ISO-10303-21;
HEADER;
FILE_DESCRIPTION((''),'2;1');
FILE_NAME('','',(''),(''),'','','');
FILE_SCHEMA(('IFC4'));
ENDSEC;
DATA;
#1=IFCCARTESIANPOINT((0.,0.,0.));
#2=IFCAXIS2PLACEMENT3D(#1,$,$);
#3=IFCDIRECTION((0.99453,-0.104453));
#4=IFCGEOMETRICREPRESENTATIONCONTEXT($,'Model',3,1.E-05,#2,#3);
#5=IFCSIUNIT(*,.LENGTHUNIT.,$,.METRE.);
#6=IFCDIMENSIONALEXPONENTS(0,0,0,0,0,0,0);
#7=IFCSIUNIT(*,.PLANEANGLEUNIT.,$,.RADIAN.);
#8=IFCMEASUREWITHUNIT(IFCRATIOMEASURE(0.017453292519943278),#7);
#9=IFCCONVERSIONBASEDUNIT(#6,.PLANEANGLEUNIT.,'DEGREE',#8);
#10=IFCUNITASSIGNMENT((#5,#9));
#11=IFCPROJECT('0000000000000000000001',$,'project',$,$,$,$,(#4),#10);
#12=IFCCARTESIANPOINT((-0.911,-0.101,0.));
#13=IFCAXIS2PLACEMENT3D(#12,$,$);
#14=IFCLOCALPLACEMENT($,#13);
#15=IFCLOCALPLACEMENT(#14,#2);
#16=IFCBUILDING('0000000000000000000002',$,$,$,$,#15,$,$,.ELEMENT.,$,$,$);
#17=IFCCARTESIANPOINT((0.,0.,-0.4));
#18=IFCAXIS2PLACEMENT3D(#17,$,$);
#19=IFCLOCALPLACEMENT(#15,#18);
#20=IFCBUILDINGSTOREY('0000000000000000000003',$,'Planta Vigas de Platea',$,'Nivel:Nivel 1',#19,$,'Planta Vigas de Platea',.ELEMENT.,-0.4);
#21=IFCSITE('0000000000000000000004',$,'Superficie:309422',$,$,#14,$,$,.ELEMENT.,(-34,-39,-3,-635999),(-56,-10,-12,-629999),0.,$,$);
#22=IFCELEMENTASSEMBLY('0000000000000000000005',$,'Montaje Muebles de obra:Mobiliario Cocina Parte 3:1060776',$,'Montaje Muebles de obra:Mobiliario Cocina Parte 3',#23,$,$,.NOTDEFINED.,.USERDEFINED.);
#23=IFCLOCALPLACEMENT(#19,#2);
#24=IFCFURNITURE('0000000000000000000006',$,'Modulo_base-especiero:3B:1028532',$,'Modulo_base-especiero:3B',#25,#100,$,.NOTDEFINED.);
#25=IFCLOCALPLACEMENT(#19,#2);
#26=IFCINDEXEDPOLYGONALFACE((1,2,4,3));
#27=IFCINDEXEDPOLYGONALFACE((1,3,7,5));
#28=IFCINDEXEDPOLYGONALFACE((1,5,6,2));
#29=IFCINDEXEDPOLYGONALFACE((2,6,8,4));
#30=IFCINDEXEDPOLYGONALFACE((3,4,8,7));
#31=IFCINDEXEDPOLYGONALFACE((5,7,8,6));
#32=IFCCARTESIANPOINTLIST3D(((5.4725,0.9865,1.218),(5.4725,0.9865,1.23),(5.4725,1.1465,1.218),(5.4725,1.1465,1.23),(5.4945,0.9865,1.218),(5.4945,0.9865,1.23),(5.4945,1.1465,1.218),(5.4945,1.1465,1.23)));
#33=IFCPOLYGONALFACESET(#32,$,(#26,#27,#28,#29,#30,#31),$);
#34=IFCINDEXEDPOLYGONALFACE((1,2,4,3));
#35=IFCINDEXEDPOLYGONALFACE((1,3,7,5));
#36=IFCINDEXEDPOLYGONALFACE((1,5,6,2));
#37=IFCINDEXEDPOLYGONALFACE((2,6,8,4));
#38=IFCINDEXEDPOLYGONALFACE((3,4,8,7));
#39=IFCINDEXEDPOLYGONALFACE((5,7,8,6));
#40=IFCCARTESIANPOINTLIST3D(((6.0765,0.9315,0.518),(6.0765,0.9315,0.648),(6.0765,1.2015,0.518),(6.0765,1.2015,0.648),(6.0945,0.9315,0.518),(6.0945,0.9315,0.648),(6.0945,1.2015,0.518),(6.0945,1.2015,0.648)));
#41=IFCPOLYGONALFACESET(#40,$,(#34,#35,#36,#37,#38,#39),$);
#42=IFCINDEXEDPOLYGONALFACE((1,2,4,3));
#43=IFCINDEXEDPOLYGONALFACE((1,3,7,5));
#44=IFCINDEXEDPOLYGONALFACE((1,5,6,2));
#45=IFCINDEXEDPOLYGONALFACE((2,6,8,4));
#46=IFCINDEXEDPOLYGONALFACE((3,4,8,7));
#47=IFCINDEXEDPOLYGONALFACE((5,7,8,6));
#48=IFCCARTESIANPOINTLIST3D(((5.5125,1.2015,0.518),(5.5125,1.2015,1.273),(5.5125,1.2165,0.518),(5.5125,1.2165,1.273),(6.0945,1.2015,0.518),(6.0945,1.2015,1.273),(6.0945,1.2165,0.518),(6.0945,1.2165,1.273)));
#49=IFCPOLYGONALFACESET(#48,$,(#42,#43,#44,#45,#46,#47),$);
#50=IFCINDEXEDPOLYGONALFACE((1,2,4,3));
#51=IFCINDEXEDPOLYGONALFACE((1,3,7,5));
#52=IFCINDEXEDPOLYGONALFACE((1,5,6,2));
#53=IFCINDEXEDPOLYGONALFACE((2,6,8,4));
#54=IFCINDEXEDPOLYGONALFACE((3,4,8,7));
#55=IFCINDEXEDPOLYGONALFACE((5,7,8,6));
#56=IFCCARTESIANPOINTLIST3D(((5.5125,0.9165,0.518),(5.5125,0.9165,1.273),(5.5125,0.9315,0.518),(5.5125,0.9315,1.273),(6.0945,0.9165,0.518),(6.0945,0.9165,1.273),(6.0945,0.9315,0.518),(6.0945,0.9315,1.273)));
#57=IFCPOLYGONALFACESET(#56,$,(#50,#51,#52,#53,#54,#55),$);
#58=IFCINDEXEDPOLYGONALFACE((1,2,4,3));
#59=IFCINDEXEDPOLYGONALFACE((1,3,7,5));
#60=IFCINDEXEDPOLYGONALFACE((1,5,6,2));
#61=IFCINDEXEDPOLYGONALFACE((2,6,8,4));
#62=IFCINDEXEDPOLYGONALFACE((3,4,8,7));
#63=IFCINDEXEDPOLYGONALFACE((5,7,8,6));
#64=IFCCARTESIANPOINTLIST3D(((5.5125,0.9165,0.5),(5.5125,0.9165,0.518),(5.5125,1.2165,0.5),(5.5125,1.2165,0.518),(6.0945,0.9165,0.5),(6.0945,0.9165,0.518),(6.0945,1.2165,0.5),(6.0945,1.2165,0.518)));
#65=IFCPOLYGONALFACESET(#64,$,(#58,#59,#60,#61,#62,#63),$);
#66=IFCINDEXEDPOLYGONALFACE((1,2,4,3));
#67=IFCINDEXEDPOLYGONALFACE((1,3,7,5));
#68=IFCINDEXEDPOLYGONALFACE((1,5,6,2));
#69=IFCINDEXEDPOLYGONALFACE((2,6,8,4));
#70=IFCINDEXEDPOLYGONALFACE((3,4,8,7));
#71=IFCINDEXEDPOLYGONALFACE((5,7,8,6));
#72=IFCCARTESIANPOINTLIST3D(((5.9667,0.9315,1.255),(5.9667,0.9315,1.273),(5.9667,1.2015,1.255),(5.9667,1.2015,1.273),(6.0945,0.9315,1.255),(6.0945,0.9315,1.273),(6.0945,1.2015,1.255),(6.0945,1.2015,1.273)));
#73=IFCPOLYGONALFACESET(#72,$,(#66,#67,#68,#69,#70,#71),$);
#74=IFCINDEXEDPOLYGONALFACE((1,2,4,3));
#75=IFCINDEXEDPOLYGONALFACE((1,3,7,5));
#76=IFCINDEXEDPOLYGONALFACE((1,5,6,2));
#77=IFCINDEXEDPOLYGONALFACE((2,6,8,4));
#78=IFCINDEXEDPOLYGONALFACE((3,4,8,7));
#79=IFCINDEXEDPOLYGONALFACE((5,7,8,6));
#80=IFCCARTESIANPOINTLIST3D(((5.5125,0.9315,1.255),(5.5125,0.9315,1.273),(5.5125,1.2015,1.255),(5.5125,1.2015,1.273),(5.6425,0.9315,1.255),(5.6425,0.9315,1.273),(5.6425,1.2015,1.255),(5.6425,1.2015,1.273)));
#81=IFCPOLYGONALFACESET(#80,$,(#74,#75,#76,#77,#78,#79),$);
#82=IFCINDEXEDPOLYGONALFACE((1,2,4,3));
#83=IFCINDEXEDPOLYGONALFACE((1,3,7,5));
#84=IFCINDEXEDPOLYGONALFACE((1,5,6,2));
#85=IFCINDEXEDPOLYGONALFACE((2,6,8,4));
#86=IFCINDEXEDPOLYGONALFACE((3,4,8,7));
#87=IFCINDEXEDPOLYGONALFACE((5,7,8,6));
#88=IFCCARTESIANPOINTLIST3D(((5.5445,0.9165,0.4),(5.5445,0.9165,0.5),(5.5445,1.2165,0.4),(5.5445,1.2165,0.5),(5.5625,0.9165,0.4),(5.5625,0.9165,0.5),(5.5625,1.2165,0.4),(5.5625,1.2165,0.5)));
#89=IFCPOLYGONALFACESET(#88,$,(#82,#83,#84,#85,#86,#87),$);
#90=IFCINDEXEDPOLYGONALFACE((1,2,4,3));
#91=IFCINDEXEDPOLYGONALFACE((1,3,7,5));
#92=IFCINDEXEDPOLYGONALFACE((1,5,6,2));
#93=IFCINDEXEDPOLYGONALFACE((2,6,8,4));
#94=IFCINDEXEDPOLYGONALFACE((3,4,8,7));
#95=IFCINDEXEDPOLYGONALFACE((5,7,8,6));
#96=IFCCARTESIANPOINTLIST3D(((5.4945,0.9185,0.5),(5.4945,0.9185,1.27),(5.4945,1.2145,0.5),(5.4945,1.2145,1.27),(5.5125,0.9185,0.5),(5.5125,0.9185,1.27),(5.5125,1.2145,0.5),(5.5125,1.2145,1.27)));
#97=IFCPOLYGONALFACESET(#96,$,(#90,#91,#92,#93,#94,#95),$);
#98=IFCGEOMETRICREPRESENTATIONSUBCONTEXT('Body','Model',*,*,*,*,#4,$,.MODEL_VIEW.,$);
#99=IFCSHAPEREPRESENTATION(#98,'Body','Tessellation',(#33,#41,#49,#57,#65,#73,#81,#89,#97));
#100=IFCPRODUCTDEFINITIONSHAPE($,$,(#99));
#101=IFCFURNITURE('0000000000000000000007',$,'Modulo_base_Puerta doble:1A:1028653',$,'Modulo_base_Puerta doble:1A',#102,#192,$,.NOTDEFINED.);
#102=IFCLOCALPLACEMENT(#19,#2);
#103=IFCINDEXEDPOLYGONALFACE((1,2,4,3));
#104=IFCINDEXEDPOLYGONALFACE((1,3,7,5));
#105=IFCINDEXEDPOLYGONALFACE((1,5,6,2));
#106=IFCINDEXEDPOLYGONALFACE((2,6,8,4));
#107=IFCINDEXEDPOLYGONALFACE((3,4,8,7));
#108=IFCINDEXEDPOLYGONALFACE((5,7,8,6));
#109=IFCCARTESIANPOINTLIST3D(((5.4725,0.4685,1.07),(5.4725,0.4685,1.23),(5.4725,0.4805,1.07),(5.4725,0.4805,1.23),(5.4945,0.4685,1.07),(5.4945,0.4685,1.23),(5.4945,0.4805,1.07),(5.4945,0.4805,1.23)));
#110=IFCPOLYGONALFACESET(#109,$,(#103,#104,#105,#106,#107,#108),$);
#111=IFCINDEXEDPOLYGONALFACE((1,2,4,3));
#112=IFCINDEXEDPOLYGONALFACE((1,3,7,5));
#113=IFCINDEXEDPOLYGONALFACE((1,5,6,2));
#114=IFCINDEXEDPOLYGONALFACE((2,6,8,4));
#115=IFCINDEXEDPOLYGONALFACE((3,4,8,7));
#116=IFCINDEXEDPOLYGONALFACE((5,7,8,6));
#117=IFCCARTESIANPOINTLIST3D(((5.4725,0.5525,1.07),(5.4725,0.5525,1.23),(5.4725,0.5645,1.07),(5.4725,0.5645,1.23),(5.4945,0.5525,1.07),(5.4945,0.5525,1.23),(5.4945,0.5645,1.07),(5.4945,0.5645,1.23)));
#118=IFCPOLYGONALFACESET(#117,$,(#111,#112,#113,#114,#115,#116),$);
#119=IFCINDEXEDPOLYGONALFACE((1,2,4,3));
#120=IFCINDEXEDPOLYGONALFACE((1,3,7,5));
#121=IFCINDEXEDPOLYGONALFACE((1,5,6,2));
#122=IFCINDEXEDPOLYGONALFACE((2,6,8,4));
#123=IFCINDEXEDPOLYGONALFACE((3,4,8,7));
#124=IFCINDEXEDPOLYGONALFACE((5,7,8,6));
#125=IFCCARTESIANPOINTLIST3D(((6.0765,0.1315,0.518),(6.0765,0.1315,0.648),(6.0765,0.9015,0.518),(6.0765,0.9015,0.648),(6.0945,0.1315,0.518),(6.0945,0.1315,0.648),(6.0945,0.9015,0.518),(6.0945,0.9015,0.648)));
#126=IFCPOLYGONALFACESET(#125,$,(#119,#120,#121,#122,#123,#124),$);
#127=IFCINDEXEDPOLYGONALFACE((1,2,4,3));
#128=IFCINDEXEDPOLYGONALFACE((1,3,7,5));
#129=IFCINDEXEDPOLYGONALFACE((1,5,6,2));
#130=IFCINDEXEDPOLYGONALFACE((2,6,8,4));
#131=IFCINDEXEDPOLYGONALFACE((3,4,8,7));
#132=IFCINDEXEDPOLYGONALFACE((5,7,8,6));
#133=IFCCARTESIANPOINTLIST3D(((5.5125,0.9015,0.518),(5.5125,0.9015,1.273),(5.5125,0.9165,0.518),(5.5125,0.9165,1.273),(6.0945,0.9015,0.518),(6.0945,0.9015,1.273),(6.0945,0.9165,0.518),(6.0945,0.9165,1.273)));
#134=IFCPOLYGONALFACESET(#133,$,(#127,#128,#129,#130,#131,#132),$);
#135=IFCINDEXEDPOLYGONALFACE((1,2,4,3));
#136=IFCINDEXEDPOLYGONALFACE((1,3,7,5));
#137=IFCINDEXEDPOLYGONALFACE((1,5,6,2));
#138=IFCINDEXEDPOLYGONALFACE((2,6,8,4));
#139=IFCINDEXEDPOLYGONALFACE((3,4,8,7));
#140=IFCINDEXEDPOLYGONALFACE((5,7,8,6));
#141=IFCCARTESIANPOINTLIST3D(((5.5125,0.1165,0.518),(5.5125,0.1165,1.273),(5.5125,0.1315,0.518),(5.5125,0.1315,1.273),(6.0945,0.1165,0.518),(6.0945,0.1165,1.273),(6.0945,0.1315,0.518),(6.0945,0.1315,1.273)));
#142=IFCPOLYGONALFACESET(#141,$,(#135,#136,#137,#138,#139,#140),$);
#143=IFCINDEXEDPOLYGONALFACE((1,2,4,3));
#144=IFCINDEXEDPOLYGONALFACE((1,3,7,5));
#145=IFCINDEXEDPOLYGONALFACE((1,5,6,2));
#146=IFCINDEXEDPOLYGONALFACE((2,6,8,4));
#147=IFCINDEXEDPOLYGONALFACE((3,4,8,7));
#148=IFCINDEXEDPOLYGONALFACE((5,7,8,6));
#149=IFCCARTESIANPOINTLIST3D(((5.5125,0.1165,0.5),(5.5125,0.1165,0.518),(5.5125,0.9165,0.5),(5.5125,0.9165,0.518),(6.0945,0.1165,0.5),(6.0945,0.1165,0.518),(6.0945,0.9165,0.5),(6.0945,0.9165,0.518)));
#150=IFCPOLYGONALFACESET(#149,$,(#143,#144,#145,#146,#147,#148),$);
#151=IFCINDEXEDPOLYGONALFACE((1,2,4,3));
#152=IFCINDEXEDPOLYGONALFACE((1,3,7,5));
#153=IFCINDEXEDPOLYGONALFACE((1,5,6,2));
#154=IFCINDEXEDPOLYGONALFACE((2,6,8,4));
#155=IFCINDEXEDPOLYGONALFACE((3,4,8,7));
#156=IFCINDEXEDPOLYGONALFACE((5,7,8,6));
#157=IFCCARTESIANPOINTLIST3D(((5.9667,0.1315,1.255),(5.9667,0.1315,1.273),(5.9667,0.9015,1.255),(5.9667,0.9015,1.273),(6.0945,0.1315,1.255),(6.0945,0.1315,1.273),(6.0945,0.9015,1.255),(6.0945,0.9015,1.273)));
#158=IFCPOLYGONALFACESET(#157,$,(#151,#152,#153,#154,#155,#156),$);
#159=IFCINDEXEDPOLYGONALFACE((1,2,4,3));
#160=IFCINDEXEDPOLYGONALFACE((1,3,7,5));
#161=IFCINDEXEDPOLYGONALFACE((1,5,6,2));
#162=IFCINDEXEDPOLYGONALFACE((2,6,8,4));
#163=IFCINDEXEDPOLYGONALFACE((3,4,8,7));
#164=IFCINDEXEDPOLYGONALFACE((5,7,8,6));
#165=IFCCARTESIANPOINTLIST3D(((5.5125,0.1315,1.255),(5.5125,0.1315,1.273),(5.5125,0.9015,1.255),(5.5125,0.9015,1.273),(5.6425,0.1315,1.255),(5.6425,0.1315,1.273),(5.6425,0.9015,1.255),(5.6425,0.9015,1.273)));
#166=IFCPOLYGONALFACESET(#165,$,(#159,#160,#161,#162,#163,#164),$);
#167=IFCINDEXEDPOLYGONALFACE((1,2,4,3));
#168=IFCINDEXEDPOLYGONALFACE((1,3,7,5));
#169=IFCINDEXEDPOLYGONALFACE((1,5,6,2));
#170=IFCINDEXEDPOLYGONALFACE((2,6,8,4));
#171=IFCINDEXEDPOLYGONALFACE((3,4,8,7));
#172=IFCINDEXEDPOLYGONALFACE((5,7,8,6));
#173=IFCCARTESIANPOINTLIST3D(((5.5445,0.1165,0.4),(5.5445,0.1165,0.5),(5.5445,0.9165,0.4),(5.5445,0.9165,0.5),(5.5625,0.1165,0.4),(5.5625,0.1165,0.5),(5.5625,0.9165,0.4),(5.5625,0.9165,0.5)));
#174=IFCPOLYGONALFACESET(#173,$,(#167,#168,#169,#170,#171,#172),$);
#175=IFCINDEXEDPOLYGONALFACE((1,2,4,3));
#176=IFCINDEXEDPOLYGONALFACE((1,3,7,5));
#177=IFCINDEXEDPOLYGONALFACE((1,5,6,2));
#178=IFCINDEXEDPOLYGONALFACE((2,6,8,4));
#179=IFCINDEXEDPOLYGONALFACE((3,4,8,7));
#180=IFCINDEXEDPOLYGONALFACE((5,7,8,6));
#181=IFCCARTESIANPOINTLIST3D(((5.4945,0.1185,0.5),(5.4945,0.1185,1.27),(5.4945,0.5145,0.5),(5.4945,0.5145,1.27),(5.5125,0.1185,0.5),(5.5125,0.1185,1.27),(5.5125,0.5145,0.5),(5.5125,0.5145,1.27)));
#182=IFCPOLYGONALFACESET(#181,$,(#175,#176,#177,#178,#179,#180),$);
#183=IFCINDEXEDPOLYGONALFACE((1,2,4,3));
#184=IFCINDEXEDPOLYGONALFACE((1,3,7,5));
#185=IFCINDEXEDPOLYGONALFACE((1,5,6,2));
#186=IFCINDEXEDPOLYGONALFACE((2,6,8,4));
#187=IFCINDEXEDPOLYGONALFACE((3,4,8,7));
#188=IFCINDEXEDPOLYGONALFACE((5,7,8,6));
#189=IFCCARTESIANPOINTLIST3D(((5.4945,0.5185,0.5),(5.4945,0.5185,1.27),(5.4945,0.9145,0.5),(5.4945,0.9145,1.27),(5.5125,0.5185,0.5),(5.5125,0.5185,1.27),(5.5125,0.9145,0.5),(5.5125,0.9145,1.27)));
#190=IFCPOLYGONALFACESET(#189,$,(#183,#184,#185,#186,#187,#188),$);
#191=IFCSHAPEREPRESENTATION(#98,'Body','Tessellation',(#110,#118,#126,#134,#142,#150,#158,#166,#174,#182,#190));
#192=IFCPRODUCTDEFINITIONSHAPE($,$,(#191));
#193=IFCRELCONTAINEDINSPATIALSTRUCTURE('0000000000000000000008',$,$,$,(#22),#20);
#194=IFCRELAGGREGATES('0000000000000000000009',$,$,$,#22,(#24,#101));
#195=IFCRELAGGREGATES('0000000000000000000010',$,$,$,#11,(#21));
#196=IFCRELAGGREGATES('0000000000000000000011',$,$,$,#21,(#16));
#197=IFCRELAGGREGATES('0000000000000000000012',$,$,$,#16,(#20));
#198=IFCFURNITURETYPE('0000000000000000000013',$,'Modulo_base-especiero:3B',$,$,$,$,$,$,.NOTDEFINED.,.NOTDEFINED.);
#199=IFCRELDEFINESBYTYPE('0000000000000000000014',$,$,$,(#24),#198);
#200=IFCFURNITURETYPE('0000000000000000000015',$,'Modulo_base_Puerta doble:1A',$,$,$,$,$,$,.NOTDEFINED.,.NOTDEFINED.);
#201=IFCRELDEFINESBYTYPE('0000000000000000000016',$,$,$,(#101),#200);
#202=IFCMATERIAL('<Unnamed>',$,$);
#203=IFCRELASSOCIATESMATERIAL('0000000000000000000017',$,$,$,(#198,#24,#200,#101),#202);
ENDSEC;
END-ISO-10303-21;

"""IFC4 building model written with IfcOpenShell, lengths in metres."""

from ifc_helpers import new_model, entity, si_unit, converted_unit, direction, frame, frame_2d, origin, origin_2d_with_axis, place, context, subcontext, project, spatial, rectangle, extrude, source, transform, mapped, material, type_object, type_shapes, element, aggregate, save


model = new_model("IFC4")

# Units and contexts
model_context = context("Model", 3, precision=1e-05, world=origin(), true_north=direction((0.99453, -0.104453)))
body_context = subcontext(model_context, "Body", "Model", "MODEL_VIEW")
ifc_project = project(units=[si_unit("LENGTHUNIT", "METRE"), converted_unit("PLANEANGLEUNIT", "DEGREE", entity("IfcRatioMeasure", 0.017453292519943278), si_unit("PLANEANGLEUNIT", "RADIAN"), dimensions=[0, 0, 0, 0, 0, 0, 0])], contexts=[model_context])

# Site, building, storey
site_placement = place(None, frame((-0.911, -0.101, 0.0)))
site = spatial("IfcSite", under=ifc_project, at=site_placement, Name="Superficie:309422", CompositionType="ELEMENT", RefLatitude=(-34, -39, -3, -635999), RefLongitude=(-56, -10, -12, -629999), RefElevation=0.0)
building_placement = place(site_placement, origin())
building = spatial("IfcBuilding", under=site, at=building_placement, CompositionType="ELEMENT")
storey_placement = place(building_placement, frame((0.0, 0.0, -0.4)))
storey = spatial("IfcBuildingStorey", under=building, at=storey_placement, Name="Planta Vigas de Platea", ObjectType="Nivel:Nivel 1", LongName="Planta Vigas de Platea", CompositionType="ELEMENT", Elevation=-0.4)

# Element assembly, furniture
ifc_material_1 = material(Name="<Unnamed>")
assembly_1_placement = place(storey_placement, origin())
assembly_1 = element("IfcElementAssembly", 1, at=assembly_1_placement, inside=storey, Name="Montaje Muebles de obra:Mobiliario Cocina Parte 3:1060776", ObjectType="Montaje Muebles de obra:Mobiliario Cocina Parte 3", AssemblyPlace="NOTDEFINED", PredefinedType="USERDEFINED")
furniture_type_1 = type_object("IfcFurnitureType", Name="Modulo_base-especiero:3B", AssemblyPlace="NOTDEFINED", PredefinedType="NOTDEFINED", material=ifc_material_1)
shared_shape_1 = source(origin(), body_context, "Body", "SweptSolid", [
    extrude(rectangle(XDim=0.022, YDim=0.16, at=frame_2d((0.0, 0.0), x_axis=(1.0, 0.0))), frame((0.011, 0.15, 0.818)), (0.0, 0.0, 1.0), 0.012),
    extrude(rectangle(XDim=0.27, YDim=0.018, at=frame_2d((0.0, 0.0), x_axis=(1.0, 0.0))), frame((0.613, 0.15, 0.118), z_axis=(0.0, 0.0, 1.0), x_axis=(0.0, 1.0, 0.0)), (0.0, 0.0, 1.0), 0.13),
    extrude(rectangle(XDim=0.015, YDim=0.582, at=frame_2d((0.0, 0.0), x_axis=(1.0, 0.0))), frame((0.331, 0.2925, 0.118), z_axis=(0.0, 0.0, 1.0), x_axis=(0.0, 1.0, 0.0)), (0.0, 0.0, 1.0), 0.755),
    extrude(rectangle(XDim=0.015, YDim=0.582, at=frame_2d((0.0, 0.0), x_axis=(1.0, 0.0))), frame((0.331, 0.0075, 0.118), z_axis=(0.0, 0.0, 1.0), x_axis=(0.0, -1.0, 0.0)), (0.0, 0.0, 1.0), 0.755),
    extrude(rectangle(XDim=0.3, YDim=0.582, at=frame_2d((0.0, 0.0), x_axis=(1.0, 0.0))), frame((0.331, 0.15, 0.1), z_axis=(0.0, 0.0, 1.0), x_axis=(0.0, 1.0, 0.0)), (0.0, 0.0, 1.0), 0.018),
    extrude(rectangle(XDim=0.27, YDim=0.1278, at=frame_2d((0.0, 0.0), x_axis=(1.0, 0.0))), frame((0.5581, 0.15, 0.855), z_axis=(0.0, 0.0, 1.0), x_axis=(0.0, 1.0, 0.0)), (0.0, 0.0, 1.0), 0.018),
    extrude(rectangle(XDim=0.27, YDim=0.13, at=frame_2d((0.0, 0.0), x_axis=(1.0, 0.0))), frame((0.105, 0.15, 0.855), z_axis=(0.0, 0.0, 1.0), x_axis=(0.0, 1.0, 0.0)), (0.0, 0.0, 1.0), 0.018),
    extrude(rectangle(XDim=0.018, YDim=0.3, at=frame_2d((0.0, 0.0), x_axis=(1.0, 0.0))), frame((0.081, 0.15, 0.0), z_axis=(0.0, 0.0, 1.0), x_axis=(-1.0, 0.0, 0.0)), (0.0, 0.0, 1.0), 0.1),
    extrude(rectangle(XDim=0.018, YDim=0.296, at=frame_2d((0.0, 0.0), x_axis=(1.0, 0.0))), frame((0.031, 0.15, 0.1)), (0.0, 0.0, 1.0), 0.77),
])
type_shapes(furniture_type_1, [shared_shape_1])
furniture_1_placement = place(assembly_1_placement, frame((5.4725, 0.9165, 0.4)))
furniture_1 = element("IfcFurniture", 2, at=furniture_1_placement, type_object=furniture_type_1, material=ifc_material_1, Name="Modulo_base-especiero:3B:1028532", ObjectType="Modulo_base-especiero:3B", PredefinedType="NOTDEFINED", context=body_context, shape_type="MappedRepresentation", body=[
    mapped(shared_shape_1, transform((0.0, 0.0, 0.0), scale=1.0)),
])
furniture_type_2 = type_object("IfcFurnitureType", Name="Modulo_base_Puerta doble:1A", AssemblyPlace="NOTDEFINED", PredefinedType="NOTDEFINED", material=ifc_material_1)
shared_shape_2 = source(origin(), body_context, "Body", "SweptSolid", [
    extrude(rectangle(XDim=0.022, YDim=0.012, at=origin_2d_with_axis()), frame((0.011, 0.358, 0.67)), (0.0, 0.0, 1.0), 0.16),
    extrude(rectangle(XDim=0.022, YDim=0.012, at=origin_2d_with_axis()), frame((0.011, 0.442, 0.67)), (0.0, 0.0, 1.0), 0.16),
    extrude(rectangle(XDim=0.77, YDim=0.018, at=frame_2d((0.0, 0.0), x_axis=(1.0, 0.0))), frame((0.613, 0.4, 0.118), z_axis=(0.0, 0.0, 1.0), x_axis=(0.0, 1.0, 0.0)), (0.0, 0.0, 1.0), 0.13),
    extrude(rectangle(XDim=0.015, YDim=0.582, at=frame_2d((0.0, 0.0), x_axis=(1.0, 0.0))), frame((0.331, 0.7925, 0.118), z_axis=(0.0, 0.0, 1.0), x_axis=(0.0, 1.0, 0.0)), (0.0, 0.0, 1.0), 0.755),
    extrude(rectangle(XDim=0.015, YDim=0.582, at=frame_2d((-0.0015, 0.0322), x_axis=(1.0, 0.0))), frame((0.2988, 0.006, 0.118), z_axis=(0.0, 0.0, 1.0), x_axis=(0.0, -1.0, 0.0)), (0.0, 0.0, 1.0), 0.755),
    extrude(rectangle(XDim=0.8, YDim=0.582, at=frame_2d((0.08, -0.0322), x_axis=(1.0, 0.0))), frame((0.2988, 0.32, 0.1), z_axis=(0.0, 0.0, 1.0), x_axis=(0.0, 1.0, 0.0)), (0.0, 0.0, 1.0), 0.018),
    extrude(rectangle(XDim=0.77, YDim=0.1278, at=frame_2d((0.0, 0.0), x_axis=(1.0, 0.0))), frame((0.5581, 0.4, 0.855), z_axis=(0.0, 0.0, 1.0), x_axis=(0.0, 1.0, 0.0)), (0.0, 0.0, 1.0), 0.018),
    extrude(rectangle(XDim=0.77, YDim=0.13, at=frame_2d((0.0, 0.0), x_axis=(1.0, 0.0))), frame((0.105, 0.4, 0.855), z_axis=(0.0, 0.0, 1.0), x_axis=(0.0, 1.0, 0.0)), (0.0, 0.0, 1.0), 0.018),
    extrude(rectangle(XDim=0.018, YDim=0.8, at=frame_2d((0.0, 0.0), x_axis=(1.0, 0.0))), frame((0.081, 0.4, 0.0), z_axis=(0.0, 0.0, 1.0), x_axis=(-1.0, 0.0, 0.0)), (0.0, 0.0, 1.0), 0.1),
    extrude(rectangle(XDim=0.018, YDim=0.396, at=origin_2d_with_axis()), frame((0.031, 0.2, 0.1)), (0.0, 0.0, 1.0), 0.77),
    extrude(rectangle(XDim=0.018, YDim=0.396, at=frame_2d((0.0, 0.0), x_axis=(1.0, 0.0))), frame((0.031, 0.6, 0.1)), (0.0, 0.0, 1.0), 0.77),
])
type_shapes(furniture_type_2, [shared_shape_2])
furniture_2_placement = place(assembly_1_placement, frame((5.4725, 0.1165, 0.4)))
furniture_2 = element("IfcFurniture", 3, at=furniture_2_placement, type_object=furniture_type_2, material=ifc_material_1, Name="Modulo_base_Puerta doble:1A:1028653", ObjectType="Modulo_base_Puerta doble:1A", PredefinedType="NOTDEFINED", context=body_context, shape_type="MappedRepresentation", body=[
    mapped(shared_shape_2, transform((0.0, 0.0, 0.0), scale=1.0)),
])

aggregate(assembly_1, [furniture_1, furniture_2])

save(model, "model.ifc")
